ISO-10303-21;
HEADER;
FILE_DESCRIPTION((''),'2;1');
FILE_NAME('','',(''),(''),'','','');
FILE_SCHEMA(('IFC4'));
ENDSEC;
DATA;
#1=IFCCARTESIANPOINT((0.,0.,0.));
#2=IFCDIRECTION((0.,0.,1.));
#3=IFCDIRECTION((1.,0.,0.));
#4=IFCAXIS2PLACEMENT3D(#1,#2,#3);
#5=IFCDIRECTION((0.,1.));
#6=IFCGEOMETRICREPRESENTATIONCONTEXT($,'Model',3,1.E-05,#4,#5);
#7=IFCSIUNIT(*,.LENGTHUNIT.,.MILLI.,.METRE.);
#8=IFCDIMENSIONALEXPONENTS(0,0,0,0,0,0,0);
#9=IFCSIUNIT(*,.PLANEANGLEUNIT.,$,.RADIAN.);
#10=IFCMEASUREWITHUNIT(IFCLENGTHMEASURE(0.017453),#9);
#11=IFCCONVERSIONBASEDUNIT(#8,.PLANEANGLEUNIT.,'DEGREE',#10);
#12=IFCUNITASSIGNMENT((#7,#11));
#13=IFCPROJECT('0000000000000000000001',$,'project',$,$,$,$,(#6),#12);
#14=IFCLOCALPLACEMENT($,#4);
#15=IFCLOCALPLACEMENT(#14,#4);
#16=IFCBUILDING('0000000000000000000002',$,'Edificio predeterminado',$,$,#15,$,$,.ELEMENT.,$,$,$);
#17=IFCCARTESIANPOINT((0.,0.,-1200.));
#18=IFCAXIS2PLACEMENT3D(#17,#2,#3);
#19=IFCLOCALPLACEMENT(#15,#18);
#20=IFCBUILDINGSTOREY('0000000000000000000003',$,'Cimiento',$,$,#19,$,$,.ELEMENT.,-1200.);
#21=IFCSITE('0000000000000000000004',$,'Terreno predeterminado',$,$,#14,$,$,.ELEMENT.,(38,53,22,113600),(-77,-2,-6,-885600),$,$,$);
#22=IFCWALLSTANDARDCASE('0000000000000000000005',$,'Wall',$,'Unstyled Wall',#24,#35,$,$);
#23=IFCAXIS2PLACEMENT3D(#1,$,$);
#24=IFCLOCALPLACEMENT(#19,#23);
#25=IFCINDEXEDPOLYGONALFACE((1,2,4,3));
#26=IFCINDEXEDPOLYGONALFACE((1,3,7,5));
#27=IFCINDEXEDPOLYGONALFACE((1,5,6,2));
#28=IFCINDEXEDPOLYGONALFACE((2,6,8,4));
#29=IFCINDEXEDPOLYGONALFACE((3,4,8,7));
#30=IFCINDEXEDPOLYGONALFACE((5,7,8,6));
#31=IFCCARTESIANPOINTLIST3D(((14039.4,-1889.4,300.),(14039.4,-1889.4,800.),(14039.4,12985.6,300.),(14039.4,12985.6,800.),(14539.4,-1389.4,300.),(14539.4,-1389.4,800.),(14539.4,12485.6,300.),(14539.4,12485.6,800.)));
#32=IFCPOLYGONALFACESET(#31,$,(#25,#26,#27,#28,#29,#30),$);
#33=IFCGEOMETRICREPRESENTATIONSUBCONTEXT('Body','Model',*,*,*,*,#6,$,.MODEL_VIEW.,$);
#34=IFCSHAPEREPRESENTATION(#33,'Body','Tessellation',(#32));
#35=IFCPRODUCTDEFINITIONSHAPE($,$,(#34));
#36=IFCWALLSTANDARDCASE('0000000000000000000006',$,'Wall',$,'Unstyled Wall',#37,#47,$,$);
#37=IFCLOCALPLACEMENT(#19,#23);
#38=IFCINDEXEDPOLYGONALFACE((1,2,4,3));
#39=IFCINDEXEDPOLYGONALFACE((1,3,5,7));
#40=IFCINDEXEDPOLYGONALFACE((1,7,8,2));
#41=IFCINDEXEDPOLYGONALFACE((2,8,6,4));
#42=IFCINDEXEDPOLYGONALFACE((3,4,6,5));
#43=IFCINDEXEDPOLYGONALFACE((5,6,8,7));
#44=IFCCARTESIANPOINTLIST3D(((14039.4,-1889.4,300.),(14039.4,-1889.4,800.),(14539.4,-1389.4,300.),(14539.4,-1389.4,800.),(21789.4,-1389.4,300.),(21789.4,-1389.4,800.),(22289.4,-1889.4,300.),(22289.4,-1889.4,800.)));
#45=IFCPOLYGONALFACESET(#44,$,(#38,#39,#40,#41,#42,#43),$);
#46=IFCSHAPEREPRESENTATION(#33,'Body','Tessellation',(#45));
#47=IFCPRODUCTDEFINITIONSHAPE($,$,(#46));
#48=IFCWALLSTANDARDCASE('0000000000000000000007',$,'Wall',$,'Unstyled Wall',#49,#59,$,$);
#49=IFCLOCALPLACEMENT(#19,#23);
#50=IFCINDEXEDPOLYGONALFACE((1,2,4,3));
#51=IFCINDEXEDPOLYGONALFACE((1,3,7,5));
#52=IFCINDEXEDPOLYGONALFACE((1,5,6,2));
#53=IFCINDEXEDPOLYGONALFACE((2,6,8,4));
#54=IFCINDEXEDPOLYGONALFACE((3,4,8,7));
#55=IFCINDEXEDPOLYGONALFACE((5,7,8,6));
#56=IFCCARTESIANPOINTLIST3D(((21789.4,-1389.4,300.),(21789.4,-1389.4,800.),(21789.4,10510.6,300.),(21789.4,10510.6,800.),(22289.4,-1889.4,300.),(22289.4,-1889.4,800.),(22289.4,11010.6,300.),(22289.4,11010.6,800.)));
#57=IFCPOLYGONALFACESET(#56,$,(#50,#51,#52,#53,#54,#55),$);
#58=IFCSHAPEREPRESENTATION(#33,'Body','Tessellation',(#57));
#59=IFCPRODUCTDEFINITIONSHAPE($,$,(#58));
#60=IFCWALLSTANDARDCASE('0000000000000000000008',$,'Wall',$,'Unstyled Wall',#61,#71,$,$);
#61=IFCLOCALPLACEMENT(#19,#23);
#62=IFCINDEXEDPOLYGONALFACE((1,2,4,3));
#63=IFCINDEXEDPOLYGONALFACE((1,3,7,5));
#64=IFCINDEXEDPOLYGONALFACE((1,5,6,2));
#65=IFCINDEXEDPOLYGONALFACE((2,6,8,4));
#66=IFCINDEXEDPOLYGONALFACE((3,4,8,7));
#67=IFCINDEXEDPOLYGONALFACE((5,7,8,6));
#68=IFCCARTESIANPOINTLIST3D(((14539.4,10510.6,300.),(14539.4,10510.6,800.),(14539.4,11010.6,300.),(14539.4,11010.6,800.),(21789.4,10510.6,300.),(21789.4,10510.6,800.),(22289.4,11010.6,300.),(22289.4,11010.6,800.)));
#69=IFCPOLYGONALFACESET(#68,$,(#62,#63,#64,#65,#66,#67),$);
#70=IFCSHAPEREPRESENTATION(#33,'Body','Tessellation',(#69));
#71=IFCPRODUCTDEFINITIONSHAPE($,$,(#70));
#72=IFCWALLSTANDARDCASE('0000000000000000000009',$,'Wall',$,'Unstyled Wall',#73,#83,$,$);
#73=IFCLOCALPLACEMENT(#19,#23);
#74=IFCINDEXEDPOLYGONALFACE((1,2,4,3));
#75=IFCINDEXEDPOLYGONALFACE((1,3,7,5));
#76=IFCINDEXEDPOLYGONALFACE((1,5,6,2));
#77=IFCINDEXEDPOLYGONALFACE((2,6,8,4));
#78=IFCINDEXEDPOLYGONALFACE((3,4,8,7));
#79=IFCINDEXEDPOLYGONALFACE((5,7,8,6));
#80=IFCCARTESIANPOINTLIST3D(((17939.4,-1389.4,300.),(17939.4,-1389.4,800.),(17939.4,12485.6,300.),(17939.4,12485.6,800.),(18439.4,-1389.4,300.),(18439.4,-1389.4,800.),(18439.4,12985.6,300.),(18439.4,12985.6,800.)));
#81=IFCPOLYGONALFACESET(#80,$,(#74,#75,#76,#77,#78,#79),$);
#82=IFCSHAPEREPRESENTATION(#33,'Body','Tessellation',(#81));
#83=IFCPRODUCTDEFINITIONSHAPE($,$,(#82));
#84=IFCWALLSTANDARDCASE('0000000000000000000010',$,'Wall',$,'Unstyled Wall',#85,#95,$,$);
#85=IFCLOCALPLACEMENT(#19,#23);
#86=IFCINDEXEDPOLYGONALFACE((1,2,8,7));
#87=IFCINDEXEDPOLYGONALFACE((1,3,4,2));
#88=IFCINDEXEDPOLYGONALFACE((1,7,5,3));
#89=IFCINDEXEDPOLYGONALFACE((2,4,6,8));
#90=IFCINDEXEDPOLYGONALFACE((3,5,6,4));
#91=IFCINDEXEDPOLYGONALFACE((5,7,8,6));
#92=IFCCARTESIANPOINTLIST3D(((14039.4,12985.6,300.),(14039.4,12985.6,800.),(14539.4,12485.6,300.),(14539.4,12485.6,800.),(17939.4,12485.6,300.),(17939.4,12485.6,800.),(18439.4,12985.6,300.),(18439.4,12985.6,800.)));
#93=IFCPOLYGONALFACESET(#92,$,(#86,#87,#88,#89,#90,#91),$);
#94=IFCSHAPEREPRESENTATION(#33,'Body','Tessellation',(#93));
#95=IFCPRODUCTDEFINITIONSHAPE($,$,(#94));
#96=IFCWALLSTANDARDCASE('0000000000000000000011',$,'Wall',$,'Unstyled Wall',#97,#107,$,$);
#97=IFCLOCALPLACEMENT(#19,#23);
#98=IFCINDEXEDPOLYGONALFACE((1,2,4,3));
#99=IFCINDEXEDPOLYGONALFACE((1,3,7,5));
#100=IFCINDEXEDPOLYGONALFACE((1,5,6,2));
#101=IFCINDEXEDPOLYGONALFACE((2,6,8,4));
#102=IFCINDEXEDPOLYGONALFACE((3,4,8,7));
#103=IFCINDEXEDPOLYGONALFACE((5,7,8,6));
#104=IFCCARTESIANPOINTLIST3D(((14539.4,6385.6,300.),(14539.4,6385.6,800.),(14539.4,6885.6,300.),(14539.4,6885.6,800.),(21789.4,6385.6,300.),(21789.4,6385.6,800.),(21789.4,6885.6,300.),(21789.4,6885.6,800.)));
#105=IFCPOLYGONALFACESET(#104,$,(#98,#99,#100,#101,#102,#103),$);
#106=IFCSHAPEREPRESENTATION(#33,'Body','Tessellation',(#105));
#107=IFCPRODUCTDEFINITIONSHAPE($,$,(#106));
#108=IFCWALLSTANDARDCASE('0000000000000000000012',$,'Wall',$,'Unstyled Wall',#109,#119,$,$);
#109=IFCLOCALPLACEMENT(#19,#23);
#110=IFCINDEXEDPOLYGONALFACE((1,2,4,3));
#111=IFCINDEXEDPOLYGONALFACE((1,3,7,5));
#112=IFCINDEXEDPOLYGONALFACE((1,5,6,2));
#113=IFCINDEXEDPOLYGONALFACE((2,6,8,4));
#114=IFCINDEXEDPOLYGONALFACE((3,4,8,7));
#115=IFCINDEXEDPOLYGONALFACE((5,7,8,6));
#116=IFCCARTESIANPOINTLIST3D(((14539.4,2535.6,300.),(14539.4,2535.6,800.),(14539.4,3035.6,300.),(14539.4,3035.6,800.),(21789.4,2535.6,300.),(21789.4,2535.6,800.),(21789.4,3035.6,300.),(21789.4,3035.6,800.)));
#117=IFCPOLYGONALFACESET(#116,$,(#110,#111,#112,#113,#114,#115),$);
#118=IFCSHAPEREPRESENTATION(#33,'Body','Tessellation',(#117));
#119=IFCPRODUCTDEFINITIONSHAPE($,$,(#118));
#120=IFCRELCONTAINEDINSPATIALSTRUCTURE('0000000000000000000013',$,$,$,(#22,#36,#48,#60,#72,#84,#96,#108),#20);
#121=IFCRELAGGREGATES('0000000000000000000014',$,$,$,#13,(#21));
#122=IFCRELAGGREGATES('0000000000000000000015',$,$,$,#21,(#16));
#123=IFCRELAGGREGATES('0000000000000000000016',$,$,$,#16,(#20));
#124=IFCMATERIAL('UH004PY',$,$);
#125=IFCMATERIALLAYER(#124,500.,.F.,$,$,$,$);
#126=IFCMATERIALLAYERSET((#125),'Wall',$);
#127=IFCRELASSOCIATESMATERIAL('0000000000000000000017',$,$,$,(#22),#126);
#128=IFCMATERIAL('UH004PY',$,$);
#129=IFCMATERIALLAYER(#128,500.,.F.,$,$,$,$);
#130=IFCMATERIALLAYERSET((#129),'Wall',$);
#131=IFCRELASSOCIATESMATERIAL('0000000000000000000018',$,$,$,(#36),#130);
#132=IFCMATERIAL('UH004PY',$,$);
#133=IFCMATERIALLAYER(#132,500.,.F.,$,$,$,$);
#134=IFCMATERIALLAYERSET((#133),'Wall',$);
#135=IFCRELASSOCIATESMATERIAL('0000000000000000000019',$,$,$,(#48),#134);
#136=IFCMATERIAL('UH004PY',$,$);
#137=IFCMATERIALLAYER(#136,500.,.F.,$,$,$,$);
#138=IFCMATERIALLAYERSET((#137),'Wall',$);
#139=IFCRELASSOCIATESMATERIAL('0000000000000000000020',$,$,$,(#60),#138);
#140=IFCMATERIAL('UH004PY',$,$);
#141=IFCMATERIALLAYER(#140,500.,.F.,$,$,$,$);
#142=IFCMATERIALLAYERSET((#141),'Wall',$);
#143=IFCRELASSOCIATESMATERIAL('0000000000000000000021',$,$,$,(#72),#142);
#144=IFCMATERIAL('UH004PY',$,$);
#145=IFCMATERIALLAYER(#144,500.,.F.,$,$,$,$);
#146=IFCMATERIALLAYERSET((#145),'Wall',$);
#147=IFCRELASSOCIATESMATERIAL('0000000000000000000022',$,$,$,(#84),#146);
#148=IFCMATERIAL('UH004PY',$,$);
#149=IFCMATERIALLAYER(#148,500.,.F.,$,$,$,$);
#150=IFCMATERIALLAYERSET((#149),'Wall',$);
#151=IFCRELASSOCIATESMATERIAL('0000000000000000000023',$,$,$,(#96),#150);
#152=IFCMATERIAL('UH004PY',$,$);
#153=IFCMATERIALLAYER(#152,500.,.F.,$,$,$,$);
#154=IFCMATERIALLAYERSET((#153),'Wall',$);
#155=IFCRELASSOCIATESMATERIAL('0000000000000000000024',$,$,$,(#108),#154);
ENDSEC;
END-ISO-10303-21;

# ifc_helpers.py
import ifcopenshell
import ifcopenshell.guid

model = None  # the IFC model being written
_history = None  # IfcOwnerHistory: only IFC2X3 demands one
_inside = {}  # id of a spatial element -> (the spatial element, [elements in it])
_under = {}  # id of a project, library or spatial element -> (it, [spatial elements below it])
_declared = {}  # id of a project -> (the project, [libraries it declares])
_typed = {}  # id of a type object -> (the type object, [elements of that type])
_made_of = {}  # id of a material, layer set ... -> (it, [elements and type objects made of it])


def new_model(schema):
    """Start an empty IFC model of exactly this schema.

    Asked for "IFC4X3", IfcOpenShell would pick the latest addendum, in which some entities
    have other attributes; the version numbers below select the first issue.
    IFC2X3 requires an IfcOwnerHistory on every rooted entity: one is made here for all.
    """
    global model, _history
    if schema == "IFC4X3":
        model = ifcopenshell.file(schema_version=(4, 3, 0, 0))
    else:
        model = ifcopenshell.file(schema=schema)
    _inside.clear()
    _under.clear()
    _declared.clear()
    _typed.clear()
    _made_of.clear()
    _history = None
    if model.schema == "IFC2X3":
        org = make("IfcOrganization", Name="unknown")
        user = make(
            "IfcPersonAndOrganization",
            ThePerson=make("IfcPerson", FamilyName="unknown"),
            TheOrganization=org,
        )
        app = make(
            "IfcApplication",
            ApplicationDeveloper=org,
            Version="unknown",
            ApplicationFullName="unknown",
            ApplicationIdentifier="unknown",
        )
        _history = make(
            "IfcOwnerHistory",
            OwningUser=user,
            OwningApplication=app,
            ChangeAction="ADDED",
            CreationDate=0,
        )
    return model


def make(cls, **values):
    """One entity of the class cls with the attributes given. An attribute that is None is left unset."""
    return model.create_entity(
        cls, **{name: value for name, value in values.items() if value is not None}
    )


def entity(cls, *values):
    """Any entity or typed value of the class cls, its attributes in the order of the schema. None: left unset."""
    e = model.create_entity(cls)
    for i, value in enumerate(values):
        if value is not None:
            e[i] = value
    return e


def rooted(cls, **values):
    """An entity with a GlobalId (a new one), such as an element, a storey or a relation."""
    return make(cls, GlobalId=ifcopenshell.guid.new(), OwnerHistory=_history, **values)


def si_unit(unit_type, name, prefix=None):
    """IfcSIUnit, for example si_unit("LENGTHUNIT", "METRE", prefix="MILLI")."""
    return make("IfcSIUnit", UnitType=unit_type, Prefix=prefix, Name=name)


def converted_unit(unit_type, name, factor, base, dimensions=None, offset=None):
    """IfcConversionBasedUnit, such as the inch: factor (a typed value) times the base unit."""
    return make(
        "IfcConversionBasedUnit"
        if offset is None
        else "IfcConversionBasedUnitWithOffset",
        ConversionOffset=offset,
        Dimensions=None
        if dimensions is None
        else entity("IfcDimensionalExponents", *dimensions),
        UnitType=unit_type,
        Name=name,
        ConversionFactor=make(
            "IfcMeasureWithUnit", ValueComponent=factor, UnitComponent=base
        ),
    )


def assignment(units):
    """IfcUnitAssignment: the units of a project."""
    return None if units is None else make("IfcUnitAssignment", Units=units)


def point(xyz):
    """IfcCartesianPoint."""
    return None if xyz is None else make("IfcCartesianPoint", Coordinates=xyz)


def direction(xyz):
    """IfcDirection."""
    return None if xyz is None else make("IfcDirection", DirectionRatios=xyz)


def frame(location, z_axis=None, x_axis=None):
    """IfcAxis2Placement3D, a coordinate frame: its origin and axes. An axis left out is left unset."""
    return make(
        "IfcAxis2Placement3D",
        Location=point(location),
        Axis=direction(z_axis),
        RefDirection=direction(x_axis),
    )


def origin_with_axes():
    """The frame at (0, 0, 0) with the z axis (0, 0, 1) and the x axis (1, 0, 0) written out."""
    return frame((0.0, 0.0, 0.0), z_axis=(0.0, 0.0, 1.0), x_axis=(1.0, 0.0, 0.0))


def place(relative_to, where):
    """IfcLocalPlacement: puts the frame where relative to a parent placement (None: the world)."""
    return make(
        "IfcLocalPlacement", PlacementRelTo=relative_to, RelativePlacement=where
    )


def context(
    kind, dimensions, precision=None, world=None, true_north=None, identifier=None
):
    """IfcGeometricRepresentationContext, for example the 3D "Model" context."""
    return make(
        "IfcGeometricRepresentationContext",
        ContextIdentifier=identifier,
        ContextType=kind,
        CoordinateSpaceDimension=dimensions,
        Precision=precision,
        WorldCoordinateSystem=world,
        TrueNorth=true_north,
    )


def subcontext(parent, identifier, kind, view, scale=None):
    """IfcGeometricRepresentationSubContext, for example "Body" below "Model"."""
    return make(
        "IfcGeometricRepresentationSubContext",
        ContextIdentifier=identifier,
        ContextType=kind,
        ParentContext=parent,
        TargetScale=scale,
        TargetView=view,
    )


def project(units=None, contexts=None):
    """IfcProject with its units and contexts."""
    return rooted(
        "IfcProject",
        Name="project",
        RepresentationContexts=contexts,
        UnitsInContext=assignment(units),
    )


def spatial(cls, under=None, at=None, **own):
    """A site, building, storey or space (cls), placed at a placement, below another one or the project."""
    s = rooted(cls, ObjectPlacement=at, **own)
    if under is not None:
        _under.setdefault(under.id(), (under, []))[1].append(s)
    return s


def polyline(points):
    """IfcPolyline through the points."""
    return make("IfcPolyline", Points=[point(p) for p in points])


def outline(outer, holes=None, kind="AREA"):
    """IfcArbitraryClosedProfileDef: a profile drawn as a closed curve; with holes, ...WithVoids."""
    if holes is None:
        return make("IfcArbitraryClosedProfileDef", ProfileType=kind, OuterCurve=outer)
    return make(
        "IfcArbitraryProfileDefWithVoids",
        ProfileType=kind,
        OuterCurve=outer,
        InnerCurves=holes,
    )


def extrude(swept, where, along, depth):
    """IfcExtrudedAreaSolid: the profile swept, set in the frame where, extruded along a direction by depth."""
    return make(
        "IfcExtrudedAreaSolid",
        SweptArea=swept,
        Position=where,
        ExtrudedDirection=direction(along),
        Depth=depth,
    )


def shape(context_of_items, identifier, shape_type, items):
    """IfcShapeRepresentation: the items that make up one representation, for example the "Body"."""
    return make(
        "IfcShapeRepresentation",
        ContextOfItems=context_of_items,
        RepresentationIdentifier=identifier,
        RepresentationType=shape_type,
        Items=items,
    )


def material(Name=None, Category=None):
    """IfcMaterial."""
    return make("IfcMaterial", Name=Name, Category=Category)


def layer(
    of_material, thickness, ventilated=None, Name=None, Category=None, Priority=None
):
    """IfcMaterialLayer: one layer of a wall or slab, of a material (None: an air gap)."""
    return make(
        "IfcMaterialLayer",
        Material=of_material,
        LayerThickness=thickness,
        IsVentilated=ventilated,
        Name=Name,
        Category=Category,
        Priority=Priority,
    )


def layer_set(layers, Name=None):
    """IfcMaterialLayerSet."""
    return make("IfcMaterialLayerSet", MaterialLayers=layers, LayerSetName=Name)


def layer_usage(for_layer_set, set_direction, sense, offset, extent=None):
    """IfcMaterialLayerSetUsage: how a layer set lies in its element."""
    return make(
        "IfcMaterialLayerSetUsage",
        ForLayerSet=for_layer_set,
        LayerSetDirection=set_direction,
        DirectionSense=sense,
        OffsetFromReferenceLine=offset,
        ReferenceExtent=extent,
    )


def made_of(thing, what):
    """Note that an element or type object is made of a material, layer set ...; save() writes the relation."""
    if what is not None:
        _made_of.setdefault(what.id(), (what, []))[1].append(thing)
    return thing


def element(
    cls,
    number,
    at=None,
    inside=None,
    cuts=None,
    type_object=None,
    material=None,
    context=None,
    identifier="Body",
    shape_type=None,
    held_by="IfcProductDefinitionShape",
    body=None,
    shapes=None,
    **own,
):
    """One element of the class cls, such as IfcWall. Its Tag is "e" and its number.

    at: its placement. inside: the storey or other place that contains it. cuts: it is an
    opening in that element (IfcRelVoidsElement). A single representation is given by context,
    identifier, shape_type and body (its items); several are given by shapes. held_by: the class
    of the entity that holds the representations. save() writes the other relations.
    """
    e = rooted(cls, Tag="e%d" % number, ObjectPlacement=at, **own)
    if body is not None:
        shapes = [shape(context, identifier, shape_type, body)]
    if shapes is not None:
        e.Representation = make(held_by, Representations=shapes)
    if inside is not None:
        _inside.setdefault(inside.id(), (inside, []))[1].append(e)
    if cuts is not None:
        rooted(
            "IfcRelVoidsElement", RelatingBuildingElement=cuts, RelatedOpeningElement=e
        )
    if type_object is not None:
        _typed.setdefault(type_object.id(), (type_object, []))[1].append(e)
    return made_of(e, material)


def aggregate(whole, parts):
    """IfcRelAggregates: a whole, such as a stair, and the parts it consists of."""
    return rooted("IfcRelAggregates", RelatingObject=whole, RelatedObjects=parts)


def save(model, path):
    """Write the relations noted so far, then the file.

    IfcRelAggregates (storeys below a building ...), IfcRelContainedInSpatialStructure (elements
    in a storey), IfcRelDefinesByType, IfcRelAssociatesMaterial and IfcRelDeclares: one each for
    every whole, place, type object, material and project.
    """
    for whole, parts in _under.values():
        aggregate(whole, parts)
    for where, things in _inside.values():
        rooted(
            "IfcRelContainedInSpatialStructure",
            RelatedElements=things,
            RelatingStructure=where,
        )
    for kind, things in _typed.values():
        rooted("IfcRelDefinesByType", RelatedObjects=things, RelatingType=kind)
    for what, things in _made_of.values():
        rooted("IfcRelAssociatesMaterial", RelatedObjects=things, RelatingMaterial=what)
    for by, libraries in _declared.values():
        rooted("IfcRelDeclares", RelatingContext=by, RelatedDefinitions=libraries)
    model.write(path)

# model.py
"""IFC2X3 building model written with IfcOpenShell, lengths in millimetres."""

from ifc_helpers import new_model, entity, si_unit, converted_unit, direction, frame, origin_with_axes, place, context, subcontext, project, spatial, polyline, outline, extrude, material, layer, layer_set, layer_usage, element, save


model = new_model("IFC2X3")

# Units and contexts
model_context = context("Model", 3, precision=1e-05, world=origin_with_axes(), true_north=direction((0.0, 1.0)))
body_context = subcontext(model_context, "Body", "Model", "MODEL_VIEW")
ifc_project = project(units=[si_unit("LENGTHUNIT", "METRE", prefix="MILLI"), converted_unit("PLANEANGLEUNIT", "DEGREE", entity("IfcLengthMeasure", 0.017453), si_unit("PLANEANGLEUNIT", "RADIAN"), dimensions=[0, 0, 0, 0, 0, 0, 0])], contexts=[model_context])

# Site, building, storey
site_placement = place(None, origin_with_axes())
site = spatial("IfcSite", under=ifc_project, at=site_placement, Name="Terreno predeterminado", CompositionType="ELEMENT", RefLatitude=(38, 53, 22, 113600), RefLongitude=(-77, -2, -6, -885600))
building_placement = place(site_placement, origin_with_axes())
building = spatial("IfcBuilding", under=site, at=building_placement, Name="Edificio predeterminado", CompositionType="ELEMENT")
storey_placement = place(building_placement, frame((0.0, 0.0, -1200.0), z_axis=(0.0, 0.0, 1.0), x_axis=(1.0, 0.0, 0.0)))
storey = spatial("IfcBuildingStorey", under=building, at=storey_placement, Name="Cimiento", CompositionType="ELEMENT", Elevation=-1200.0)

# Walls
ifc_material_1 = material(Name="UH004PY")
ifc_layer_1 = layer(ifc_material_1, 500.0, ventilated=False)
ifc_layer_set_1 = layer_set([ifc_layer_1], Name="Wall")
ifc_layer_usage_1 = layer_usage(ifc_layer_set_1, "AXIS2", "POSITIVE", -250.0)
wall_1_placement = place(storey_placement, frame((14289.4, 12735.6, 300.0), z_axis=(0.0, 0.0, 1.0), x_axis=(0.0, -1.0, 0.0)))
element("IfcWallStandardCase", 1, at=wall_1_placement, inside=storey, material=ifc_layer_usage_1, Name="Wall", ObjectType="Unstyled Wall", context=body_context, shape_type="SweptSolid", body=[
    extrude(outline(polyline([(250.0, 250.0), (-250.0, -250.0), (14625.0, -250.0), (14125.0, 250.0), (250.0, 250.0)])), origin_with_axes(), (0.0, 0.0, 1.0), 500.0),
])
ifc_material_2 = material(Name="UH004PY")
ifc_layer_2 = layer(ifc_material_2, 500.0, ventilated=False)
ifc_layer_set_2 = layer_set([ifc_layer_2], Name="Wall")
ifc_layer_usage_2 = layer_usage(ifc_layer_set_2, "AXIS2", "POSITIVE", -250.0)
wall_2_placement = place(storey_placement, frame((14289.4, -1639.4, 300.0), z_axis=(0.0, 0.0, 1.0), x_axis=(1.0, 0.0, 0.0)))
element("IfcWallStandardCase", 2, at=wall_2_placement, inside=storey, material=ifc_layer_usage_2, Name="Wall", ObjectType="Unstyled Wall", context=body_context, shape_type="SweptSolid", body=[
    extrude(outline(polyline([(-250.0, -250.0), (250.0, 250.0), (7500.0, 250.0), (8000.0, -250.0), (-250.0, -250.0)])), origin_with_axes(), (0.0, 0.0, 1.0), 500.0),
])
ifc_material_3 = material(Name="UH004PY")
ifc_layer_3 = layer(ifc_material_3, 500.0, ventilated=False)
ifc_layer_set_3 = layer_set([ifc_layer_3], Name="Wall")
ifc_layer_usage_3 = layer_usage(ifc_layer_set_3, "AXIS2", "POSITIVE", -250.0)
wall_3_placement = place(storey_placement, frame((22039.4, -1639.4, 300.0), z_axis=(0.0, 0.0, 1.0), x_axis=(0.0, 1.0, 0.0)))
element("IfcWallStandardCase", 3, at=wall_3_placement, inside=storey, material=ifc_layer_usage_3, Name="Wall", ObjectType="Unstyled Wall", context=body_context, shape_type="SweptSolid", body=[
    extrude(outline(polyline([(-250.0, -250.0), (250.0, 250.0), (12150.0, 250.0), (12650.0, -250.0), (-250.0, -250.0)])), origin_with_axes(), (0.0, 0.0, 1.0), 500.0),
])
ifc_material_4 = material(Name="UH004PY")
ifc_layer_4 = layer(ifc_material_4, 500.0, ventilated=False)
ifc_layer_set_4 = layer_set([ifc_layer_4], Name="Wall")
ifc_layer_usage_4 = layer_usage(ifc_layer_set_4, "AXIS2", "POSITIVE", -250.0)
wall_4_placement = place(storey_placement, frame((22039.4, 10760.6, 300.0), z_axis=(0.0, 0.0, 1.0), x_axis=(-1.0, 0.0, 0.0)))
element("IfcWallStandardCase", 4, at=wall_4_placement, inside=storey, material=ifc_layer_usage_4, Name="Wall", ObjectType="Unstyled Wall", context=body_context, shape_type="SweptSolid", body=[
    extrude(outline(polyline([(-250.0, -250.0), (250.0, 250.0), (7500.0, 250.0), (7500.0, -250.0), (-250.0, -250.0)])), origin_with_axes(), (0.0, 0.0, 1.0), 500.0),
])
ifc_material_5 = material(Name="UH004PY")
ifc_layer_5 = layer(ifc_material_5, 500.0, ventilated=False)
ifc_layer_set_5 = layer_set([ifc_layer_5], Name="Wall")
ifc_layer_usage_5 = layer_usage(ifc_layer_set_5, "AXIS2", "POSITIVE", -250.0)
wall_5_placement = place(storey_placement, frame((18189.4, -1639.4, 300.0), z_axis=(0.0, 0.0, 1.0), x_axis=(0.0, 1.0, 0.0)))
element("IfcWallStandardCase", 5, at=wall_5_placement, inside=storey, material=ifc_layer_usage_5, Name="Wall", ObjectType="Unstyled Wall", context=body_context, shape_type="SweptSolid", body=[
    extrude(outline(polyline([(250.0, 250.0), (250.0, -250.0), (14625.0, -250.0), (14125.0, 250.0), (250.0, 250.0)])), origin_with_axes(), (0.0, 0.0, 1.0), 500.0),
])
ifc_material_6 = material(Name="UH004PY")
ifc_layer_6 = layer(ifc_material_6, 500.0, ventilated=False)
ifc_layer_set_6 = layer_set([ifc_layer_6], Name="Wall")
ifc_layer_usage_6 = layer_usage(ifc_layer_set_6, "AXIS2", "POSITIVE", -250.0)
wall_6_placement = place(storey_placement, frame((18189.4, 12735.6, 300.0), z_axis=(0.0, 0.0, 1.0), x_axis=(-1.0, 0.0, 0.0)))
element("IfcWallStandardCase", 6, at=wall_6_placement, inside=storey, material=ifc_layer_usage_6, Name="Wall", ObjectType="Unstyled Wall", context=body_context, shape_type="SweptSolid", body=[
    extrude(outline(polyline([(-250.0, -250.0), (250.0, 250.0), (3650.0, 250.0), (4150.0, -250.0), (-250.0, -250.0)])), origin_with_axes(), (0.0, 0.0, 1.0), 500.0),
])
ifc_material_7 = material(Name="UH004PY")
ifc_layer_7 = layer(ifc_material_7, 500.0, ventilated=False)
ifc_layer_set_7 = layer_set([ifc_layer_7], Name="Wall")
ifc_layer_usage_7 = layer_usage(ifc_layer_set_7, "AXIS2", "POSITIVE", -250.0)
wall_7_placement = place(storey_placement, frame((14289.4, 6635.6, 300.0), z_axis=(0.0, 0.0, 1.0), x_axis=(1.0, 0.0, 0.0)))
element("IfcWallStandardCase", 7, at=wall_7_placement, inside=storey, material=ifc_layer_usage_7, Name="Wall", ObjectType="Unstyled Wall", context=body_context, shape_type="SweptSolid", body=[
    extrude(outline(polyline([(250.0, -250.0), (250.0, 250.0), (7500.0, 250.0), (7500.0, -250.0), (250.0, -250.0)])), origin_with_axes(), (0.0, 0.0, 1.0), 500.0),
])
ifc_material_8 = material(Name="UH004PY")
ifc_layer_8 = layer(ifc_material_8, 500.0, ventilated=False)
ifc_layer_set_8 = layer_set([ifc_layer_8], Name="Wall")
ifc_layer_usage_8 = layer_usage(ifc_layer_set_8, "AXIS2", "POSITIVE", -250.0)
wall_8_placement = place(storey_placement, frame((14289.4, 2785.6, 300.0), z_axis=(0.0, 0.0, 1.0), x_axis=(1.0, 0.0, 0.0)))
element("IfcWallStandardCase", 8, at=wall_8_placement, inside=storey, material=ifc_layer_usage_8, Name="Wall", ObjectType="Unstyled Wall", context=body_context, shape_type="SweptSolid", body=[
    extrude(outline(polyline([(250.0, -250.0), (250.0, 250.0), (7500.0, 250.0), (7500.0, -250.0), (250.0, -250.0)])), origin_with_axes(), (0.0, 0.0, 1.0), 500.0),
])

save(model, "model.ifc")
